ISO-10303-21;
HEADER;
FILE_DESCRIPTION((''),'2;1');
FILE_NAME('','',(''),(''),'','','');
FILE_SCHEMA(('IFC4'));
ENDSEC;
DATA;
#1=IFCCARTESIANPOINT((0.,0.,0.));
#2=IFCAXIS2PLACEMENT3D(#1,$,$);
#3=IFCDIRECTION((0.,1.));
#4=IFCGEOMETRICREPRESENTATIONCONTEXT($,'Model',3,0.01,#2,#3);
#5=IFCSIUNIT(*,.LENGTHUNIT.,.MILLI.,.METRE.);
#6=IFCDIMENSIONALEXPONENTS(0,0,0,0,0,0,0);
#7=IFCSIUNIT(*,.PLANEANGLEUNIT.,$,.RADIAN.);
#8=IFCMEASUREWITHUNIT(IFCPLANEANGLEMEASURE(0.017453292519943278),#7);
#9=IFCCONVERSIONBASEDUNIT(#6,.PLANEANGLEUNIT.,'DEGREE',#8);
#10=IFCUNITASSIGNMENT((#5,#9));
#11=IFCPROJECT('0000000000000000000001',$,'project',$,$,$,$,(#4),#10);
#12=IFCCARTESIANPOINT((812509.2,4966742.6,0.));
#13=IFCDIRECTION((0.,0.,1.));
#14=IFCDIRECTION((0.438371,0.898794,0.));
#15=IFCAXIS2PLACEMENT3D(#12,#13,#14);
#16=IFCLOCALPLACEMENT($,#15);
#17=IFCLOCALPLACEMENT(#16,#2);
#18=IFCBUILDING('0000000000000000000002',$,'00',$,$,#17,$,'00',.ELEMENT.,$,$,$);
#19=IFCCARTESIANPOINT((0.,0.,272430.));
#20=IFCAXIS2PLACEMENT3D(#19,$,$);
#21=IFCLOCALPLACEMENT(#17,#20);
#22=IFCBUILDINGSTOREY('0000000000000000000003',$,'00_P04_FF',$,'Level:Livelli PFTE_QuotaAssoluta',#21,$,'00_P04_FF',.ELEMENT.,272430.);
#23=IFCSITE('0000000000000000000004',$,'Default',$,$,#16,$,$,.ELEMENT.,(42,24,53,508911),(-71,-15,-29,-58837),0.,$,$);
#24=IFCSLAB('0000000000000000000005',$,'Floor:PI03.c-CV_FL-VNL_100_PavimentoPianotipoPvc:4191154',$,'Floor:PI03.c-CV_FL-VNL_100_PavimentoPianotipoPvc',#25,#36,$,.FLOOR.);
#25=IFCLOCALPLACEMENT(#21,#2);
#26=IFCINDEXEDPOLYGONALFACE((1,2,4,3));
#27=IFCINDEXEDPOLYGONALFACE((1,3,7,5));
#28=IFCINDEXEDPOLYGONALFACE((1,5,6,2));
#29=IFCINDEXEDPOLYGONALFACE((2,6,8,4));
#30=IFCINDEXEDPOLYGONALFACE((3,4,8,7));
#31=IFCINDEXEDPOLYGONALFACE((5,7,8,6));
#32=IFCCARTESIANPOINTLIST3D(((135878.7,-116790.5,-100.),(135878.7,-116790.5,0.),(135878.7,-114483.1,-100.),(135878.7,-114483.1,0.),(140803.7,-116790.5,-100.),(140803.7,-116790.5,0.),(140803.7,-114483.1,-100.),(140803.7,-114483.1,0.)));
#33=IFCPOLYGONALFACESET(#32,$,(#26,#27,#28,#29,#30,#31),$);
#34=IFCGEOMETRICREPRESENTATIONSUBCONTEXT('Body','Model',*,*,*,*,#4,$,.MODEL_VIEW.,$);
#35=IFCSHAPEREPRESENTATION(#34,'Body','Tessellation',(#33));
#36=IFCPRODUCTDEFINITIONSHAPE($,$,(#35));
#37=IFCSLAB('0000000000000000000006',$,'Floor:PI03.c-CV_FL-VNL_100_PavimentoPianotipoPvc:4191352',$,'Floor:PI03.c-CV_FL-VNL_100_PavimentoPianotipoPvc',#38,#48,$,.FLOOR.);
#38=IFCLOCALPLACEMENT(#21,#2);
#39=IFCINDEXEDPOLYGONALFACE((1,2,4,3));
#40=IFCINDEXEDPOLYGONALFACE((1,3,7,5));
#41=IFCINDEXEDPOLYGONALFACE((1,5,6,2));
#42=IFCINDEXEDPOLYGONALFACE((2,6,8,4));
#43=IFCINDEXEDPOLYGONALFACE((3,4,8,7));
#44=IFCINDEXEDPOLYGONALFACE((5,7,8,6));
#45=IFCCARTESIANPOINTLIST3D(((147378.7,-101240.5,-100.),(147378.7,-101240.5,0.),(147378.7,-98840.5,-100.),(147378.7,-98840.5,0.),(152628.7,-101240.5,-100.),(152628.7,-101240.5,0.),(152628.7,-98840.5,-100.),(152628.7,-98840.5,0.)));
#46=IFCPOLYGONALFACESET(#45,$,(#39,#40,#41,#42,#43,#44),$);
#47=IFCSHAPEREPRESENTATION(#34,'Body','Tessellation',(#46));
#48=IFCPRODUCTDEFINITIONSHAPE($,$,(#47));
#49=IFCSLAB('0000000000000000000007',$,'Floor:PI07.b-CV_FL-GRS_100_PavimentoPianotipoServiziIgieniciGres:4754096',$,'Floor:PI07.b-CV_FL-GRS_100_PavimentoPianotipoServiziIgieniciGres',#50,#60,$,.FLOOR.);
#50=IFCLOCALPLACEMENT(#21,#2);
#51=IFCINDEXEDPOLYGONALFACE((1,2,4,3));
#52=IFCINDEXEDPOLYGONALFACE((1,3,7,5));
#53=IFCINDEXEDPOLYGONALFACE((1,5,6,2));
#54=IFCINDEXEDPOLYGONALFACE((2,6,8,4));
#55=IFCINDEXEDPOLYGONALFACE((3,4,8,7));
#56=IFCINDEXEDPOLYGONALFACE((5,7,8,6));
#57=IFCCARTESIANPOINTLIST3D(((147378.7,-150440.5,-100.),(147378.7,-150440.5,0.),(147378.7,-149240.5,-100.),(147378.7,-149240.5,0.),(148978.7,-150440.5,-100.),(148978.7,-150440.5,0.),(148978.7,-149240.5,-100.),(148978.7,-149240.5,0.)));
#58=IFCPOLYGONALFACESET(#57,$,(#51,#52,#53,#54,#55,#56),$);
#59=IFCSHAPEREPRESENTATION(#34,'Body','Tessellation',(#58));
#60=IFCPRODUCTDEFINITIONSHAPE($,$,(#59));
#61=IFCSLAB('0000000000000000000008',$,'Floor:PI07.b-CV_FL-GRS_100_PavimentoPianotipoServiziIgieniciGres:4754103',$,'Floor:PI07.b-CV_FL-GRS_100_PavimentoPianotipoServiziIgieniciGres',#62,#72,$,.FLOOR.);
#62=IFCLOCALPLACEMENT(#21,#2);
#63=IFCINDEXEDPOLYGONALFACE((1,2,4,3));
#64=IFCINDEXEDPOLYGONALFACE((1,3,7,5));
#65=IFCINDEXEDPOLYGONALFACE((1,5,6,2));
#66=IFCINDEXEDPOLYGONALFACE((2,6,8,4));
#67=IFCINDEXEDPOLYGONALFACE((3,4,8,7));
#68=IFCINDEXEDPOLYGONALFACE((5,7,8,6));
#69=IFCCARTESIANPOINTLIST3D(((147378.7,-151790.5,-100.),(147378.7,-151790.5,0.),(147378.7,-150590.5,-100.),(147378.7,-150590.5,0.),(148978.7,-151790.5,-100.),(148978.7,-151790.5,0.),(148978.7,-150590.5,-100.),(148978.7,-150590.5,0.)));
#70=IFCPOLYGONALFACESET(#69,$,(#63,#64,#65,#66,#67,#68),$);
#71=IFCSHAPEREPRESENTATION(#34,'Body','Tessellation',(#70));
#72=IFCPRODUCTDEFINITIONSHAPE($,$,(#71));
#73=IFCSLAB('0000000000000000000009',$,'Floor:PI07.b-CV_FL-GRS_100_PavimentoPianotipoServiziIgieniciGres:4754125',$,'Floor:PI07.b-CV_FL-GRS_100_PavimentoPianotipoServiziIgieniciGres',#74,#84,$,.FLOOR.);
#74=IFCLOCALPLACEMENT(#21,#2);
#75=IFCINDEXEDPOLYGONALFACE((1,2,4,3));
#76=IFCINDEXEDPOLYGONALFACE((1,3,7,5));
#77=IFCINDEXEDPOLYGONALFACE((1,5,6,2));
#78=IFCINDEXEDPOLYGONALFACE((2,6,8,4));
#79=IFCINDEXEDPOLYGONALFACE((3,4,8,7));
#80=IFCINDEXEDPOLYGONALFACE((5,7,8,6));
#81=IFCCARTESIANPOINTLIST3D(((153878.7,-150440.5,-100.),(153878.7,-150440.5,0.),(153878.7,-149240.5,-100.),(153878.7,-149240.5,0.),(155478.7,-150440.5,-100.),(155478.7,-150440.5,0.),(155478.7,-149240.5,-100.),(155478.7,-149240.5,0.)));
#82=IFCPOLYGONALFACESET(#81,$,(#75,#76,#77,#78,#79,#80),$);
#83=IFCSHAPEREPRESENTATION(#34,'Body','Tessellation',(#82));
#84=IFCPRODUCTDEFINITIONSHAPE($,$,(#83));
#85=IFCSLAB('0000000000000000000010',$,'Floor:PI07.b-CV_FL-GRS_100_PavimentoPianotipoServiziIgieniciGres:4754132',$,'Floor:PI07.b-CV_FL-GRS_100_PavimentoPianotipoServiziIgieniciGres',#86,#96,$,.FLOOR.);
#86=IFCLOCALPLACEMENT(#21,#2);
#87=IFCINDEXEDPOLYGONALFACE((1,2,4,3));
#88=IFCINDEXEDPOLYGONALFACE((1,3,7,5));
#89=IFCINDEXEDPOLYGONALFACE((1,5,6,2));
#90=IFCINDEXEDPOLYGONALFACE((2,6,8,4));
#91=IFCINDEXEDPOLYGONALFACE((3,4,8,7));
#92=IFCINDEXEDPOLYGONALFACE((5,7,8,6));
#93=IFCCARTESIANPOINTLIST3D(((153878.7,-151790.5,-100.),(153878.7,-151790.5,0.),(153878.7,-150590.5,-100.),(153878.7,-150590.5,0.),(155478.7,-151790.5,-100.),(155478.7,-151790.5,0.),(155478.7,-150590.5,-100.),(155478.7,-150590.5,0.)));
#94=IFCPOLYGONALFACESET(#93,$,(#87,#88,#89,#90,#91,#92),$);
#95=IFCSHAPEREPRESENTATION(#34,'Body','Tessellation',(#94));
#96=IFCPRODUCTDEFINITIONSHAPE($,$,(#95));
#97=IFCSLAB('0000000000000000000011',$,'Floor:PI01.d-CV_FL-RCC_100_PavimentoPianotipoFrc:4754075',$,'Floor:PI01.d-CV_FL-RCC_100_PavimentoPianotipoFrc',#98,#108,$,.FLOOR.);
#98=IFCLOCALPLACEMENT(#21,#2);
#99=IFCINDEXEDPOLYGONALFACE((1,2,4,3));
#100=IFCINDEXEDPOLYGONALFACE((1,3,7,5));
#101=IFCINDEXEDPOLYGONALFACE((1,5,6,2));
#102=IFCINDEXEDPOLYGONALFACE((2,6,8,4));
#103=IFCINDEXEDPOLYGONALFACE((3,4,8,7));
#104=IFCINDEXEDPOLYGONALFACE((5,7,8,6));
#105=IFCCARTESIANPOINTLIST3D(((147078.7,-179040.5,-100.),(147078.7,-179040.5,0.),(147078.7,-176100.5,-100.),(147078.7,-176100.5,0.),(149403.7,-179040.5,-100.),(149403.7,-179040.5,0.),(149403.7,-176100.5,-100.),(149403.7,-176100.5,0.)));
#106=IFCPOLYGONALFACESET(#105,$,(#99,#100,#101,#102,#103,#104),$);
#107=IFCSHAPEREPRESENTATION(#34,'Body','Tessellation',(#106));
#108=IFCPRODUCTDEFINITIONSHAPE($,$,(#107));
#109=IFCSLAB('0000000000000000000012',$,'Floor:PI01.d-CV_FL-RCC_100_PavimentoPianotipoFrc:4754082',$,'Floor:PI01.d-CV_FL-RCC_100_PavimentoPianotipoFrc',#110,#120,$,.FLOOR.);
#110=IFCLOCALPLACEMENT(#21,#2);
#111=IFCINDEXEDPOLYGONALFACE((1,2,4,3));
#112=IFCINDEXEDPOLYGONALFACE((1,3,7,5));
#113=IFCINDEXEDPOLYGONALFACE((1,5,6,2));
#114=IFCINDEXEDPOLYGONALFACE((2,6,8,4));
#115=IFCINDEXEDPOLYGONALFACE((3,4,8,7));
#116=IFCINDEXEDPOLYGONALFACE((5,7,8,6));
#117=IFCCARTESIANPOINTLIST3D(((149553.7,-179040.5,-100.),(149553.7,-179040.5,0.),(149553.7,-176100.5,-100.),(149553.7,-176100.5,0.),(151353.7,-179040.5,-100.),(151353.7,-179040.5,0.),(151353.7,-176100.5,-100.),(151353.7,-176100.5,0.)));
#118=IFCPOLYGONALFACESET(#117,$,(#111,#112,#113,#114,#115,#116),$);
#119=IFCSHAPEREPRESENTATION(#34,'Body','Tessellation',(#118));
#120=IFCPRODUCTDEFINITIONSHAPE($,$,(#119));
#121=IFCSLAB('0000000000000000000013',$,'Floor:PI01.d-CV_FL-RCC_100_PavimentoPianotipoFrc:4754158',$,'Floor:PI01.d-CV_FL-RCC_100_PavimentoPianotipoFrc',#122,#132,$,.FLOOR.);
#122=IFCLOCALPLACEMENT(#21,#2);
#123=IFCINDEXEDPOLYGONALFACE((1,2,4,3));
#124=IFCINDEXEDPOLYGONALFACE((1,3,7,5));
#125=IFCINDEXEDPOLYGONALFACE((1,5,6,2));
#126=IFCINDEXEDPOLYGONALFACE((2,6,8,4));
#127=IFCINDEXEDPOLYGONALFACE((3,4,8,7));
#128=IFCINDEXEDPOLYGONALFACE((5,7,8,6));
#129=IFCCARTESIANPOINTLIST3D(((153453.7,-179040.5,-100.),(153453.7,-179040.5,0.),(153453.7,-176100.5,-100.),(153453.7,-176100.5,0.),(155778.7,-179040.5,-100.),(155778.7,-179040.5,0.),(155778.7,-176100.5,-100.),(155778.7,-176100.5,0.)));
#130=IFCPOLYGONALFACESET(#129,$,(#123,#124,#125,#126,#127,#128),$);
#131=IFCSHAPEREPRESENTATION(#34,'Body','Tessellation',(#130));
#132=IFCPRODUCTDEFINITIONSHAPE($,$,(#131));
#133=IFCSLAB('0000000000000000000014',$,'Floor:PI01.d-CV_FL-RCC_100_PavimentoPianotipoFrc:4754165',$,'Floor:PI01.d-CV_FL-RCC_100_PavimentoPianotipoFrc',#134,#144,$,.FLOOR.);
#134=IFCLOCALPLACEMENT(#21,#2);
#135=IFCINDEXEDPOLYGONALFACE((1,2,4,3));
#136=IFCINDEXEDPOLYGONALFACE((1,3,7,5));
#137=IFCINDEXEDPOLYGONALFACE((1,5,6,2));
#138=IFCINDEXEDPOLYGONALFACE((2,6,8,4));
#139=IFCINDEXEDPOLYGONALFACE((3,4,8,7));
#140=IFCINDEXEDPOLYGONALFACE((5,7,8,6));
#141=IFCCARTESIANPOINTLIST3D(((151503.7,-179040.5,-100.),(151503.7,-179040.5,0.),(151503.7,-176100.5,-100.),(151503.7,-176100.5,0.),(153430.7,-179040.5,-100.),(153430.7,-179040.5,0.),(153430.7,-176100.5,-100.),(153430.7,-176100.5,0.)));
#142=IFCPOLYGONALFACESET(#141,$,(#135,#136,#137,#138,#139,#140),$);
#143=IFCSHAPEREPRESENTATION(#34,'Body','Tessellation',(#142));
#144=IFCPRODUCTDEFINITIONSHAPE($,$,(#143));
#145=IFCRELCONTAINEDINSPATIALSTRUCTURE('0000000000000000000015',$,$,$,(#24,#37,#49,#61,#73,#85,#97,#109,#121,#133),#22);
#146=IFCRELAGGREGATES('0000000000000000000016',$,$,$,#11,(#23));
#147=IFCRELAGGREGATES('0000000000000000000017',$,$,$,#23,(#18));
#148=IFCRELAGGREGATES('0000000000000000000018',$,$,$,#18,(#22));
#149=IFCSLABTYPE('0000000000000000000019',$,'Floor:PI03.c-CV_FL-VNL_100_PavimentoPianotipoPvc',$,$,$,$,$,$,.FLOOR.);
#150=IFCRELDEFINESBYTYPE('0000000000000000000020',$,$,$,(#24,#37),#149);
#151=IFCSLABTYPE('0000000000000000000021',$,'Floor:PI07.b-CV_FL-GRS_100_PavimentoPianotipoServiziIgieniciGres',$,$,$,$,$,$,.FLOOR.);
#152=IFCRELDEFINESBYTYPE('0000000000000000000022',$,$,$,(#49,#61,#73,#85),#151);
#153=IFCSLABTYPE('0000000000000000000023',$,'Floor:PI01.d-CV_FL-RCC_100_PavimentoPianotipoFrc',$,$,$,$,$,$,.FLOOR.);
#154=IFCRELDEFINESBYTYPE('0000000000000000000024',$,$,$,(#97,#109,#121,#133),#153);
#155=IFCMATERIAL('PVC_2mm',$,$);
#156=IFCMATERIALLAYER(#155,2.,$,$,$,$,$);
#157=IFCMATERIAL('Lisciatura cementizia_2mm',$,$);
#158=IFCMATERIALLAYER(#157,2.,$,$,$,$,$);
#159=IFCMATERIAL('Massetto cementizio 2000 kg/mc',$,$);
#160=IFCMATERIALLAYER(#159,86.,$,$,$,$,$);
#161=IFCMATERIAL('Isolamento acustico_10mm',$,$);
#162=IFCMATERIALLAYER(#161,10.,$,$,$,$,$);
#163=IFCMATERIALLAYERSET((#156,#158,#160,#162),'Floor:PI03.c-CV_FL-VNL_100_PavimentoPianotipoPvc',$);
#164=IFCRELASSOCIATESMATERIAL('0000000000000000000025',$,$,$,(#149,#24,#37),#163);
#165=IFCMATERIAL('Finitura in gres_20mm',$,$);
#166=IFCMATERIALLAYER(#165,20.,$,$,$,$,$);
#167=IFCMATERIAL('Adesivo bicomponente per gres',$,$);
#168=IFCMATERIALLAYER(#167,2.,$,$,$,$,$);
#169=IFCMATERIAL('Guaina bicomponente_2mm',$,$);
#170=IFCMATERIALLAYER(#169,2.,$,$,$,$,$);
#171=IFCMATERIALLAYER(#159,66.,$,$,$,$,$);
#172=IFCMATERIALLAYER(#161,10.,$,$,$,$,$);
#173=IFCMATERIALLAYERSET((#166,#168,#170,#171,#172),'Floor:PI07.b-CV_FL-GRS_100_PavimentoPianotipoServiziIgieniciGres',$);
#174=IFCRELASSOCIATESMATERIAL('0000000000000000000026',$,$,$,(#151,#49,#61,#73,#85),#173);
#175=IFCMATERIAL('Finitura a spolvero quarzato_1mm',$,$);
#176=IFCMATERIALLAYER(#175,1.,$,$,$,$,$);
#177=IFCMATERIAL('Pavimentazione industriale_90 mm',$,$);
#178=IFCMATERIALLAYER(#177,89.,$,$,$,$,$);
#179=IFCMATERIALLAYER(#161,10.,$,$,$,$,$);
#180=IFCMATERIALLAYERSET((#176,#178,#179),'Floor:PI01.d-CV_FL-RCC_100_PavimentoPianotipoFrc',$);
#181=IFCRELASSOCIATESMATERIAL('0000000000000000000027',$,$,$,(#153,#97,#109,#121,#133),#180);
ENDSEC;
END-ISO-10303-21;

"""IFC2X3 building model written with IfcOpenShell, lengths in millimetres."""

from ifc_helpers import new_model, entity, si_unit, converted_unit, direction, frame, frame_2d, origin, place, context, subcontext, project, spatial, rectangle, extrude, material, layer, layer_set, layer_usage, type_object, element, save


model = new_model("IFC2X3")

# Units and contexts
model_context = context("Model", 3, precision=0.01, world=origin(), true_north=direction((0.0, 1.0)))
body_context = subcontext(model_context, "Body", "Model", "MODEL_VIEW")
ifc_project = project(units=[si_unit("LENGTHUNIT", "METRE", prefix="MILLI"), converted_unit("PLANEANGLEUNIT", "DEGREE", entity("IfcPlaneAngleMeasure", 0.017453292519943278), si_unit("PLANEANGLEUNIT", "RADIAN"), dimensions=[0, 0, 0, 0, 0, 0, 0])], contexts=[model_context])

# Site, building, storey
site_placement = place(None, frame((812509.2, 4966742.6, 0.0), z_axis=(0.0, 0.0, 1.0), x_axis=(0.438371, 0.898794, 0.0)))
site = spatial("IfcSite", under=ifc_project, at=site_placement, Name="Default", CompositionType="ELEMENT", RefLatitude=(42, 24, 53, 508911), RefLongitude=(-71, -15, -29, -58837), RefElevation=0.0)
building_placement = place(site_placement, origin())
building = spatial("IfcBuilding", under=site, at=building_placement, Name="00", LongName="00", CompositionType="ELEMENT")
storey_placement = place(building_placement, frame((0.0, 0.0, 272430.0)))
storey = spatial("IfcBuildingStorey", under=building, at=storey_placement, Name="00_P04_FF", ObjectType="Level:Livelli PFTE_QuotaAssoluta", LongName="00_P04_FF", CompositionType="ELEMENT", Elevation=272430.0)

# Slabs
ifc_material_1 = material(Name="PVC_2mm")
ifc_layer_1 = layer(ifc_material_1, 2.0)
ifc_material_2 = material(Name="Lisciatura cementizia_2mm")
ifc_layer_2 = layer(ifc_material_2, 2.0)
ifc_material_3 = material(Name="Massetto cementizio 2000 kg/mc")
ifc_layer_3 = layer(ifc_material_3, 86.0)
ifc_material_4 = material(Name="Isolamento acustico_10mm")
ifc_layer_4 = layer(ifc_material_4, 10.0)
ifc_layer_set_1 = layer_set([ifc_layer_1, ifc_layer_2, ifc_layer_3, ifc_layer_4], Name="Floor:PI03.c-CV_FL-VNL_100_PavimentoPianotipoPvc")
ifc_layer_usage_1 = layer_usage(ifc_layer_set_1, "AXIS3", "POSITIVE", 0.0)
slab_type_1 = type_object("IfcSlabType", Name="Floor:PI03.c-CV_FL-VNL_100_PavimentoPianotipoPvc", PredefinedType="FLOOR", material=ifc_layer_set_1)
slab_1_placement = place(storey_placement, origin())
element("IfcSlab", 1, at=slab_1_placement, inside=storey, type_object=slab_type_1, material=ifc_layer_usage_1, Name="Floor:PI03.c-CV_FL-VNL_100_PavimentoPianotipoPvc:4191154", ObjectType="Floor:PI03.c-CV_FL-VNL_100_PavimentoPianotipoPvc", PredefinedType="FLOOR", context=body_context, shape_type="SweptSolid", body=[
    extrude(rectangle(XDim=2307.4, YDim=4925.0, at=frame_2d((0.0, 0.0), x_axis=(1.0, 0.0))), frame((138341.2, -115636.8, 0.0), z_axis=(0.0, 0.0, -1.0), x_axis=(0.0, 1.0, 0.0)), (0.0, 0.0, 1.0), 100.0),
])
ifc_layer_usage_2 = layer_usage(ifc_layer_set_1, "AXIS3", "POSITIVE", 0.0)
slab_2_placement = place(storey_placement, origin())
element("IfcSlab", 2, at=slab_2_placement, inside=storey, type_object=slab_type_1, material=ifc_layer_usage_2, Name="Floor:PI03.c-CV_FL-VNL_100_PavimentoPianotipoPvc:4191352", ObjectType="Floor:PI03.c-CV_FL-VNL_100_PavimentoPianotipoPvc", PredefinedType="FLOOR", context=body_context, shape_type="SweptSolid", body=[
    extrude(rectangle(XDim=2400.0, YDim=5250.0, at=frame_2d((0.0, 0.0), x_axis=(1.0, 0.0))), frame((150003.7, -100040.5, 0.0), z_axis=(0.0, 0.0, -1.0), x_axis=(0.0, 1.0, 0.0)), (0.0, 0.0, 1.0), 100.0),
])

# Slabs
ifc_material_5 = material(Name="Finitura in gres_20mm")
ifc_layer_5 = layer(ifc_material_5, 20.0)
ifc_material_6 = material(Name="Adesivo bicomponente per gres")
ifc_layer_6 = layer(ifc_material_6, 2.0)
ifc_material_7 = material(Name="Guaina bicomponente_2mm")
ifc_layer_7 = layer(ifc_material_7, 2.0)
ifc_layer_8 = layer(ifc_material_3, 66.0)
ifc_layer_9 = layer(ifc_material_4, 10.0)
ifc_layer_set_2 = layer_set([ifc_layer_5, ifc_layer_6, ifc_layer_7, ifc_layer_8, ifc_layer_9], Name="Floor:PI07.b-CV_FL-GRS_100_PavimentoPianotipoServiziIgieniciGres")
ifc_layer_usage_3 = layer_usage(ifc_layer_set_2, "AXIS3", "POSITIVE", 0.0)
slab_type_2 = type_object("IfcSlabType", Name="Floor:PI07.b-CV_FL-GRS_100_PavimentoPianotipoServiziIgieniciGres", PredefinedType="FLOOR", material=ifc_layer_set_2)
slab_3_placement = place(storey_placement, origin())
element("IfcSlab", 3, at=slab_3_placement, inside=storey, type_object=slab_type_2, material=ifc_layer_usage_3, Name="Floor:PI07.b-CV_FL-GRS_100_PavimentoPianotipoServiziIgieniciGres:4754096", ObjectType="Floor:PI07.b-CV_FL-GRS_100_PavimentoPianotipoServiziIgieniciGres", PredefinedType="FLOOR", context=body_context, shape_type="SweptSolid", body=[
    extrude(rectangle(XDim=1200.0, YDim=1600.0, at=frame_2d((0.0, 0.0), x_axis=(1.0, 0.0))), frame((148178.7, -149840.5, 0.0), z_axis=(0.0, 0.0, -1.0), x_axis=(0.0, 1.0, 0.0)), (0.0, 0.0, 1.0), 100.0),
])
ifc_layer_usage_4 = layer_usage(ifc_layer_set_2, "AXIS3", "POSITIVE", 0.0)
slab_4_placement = place(storey_placement, origin())
element("IfcSlab", 4, at=slab_4_placement, inside=storey, type_object=slab_type_2, material=ifc_layer_usage_4, Name="Floor:PI07.b-CV_FL-GRS_100_PavimentoPianotipoServiziIgieniciGres:4754103", ObjectType="Floor:PI07.b-CV_FL-GRS_100_PavimentoPianotipoServiziIgieniciGres", PredefinedType="FLOOR", context=body_context, shape_type="SweptSolid", body=[
    extrude(rectangle(XDim=1200.0, YDim=1600.0, at=frame_2d((0.0, 0.0), x_axis=(1.0, 0.0))), frame((148178.7, -151190.5, 0.0), z_axis=(0.0, 0.0, -1.0), x_axis=(0.0, 1.0, 0.0)), (0.0, 0.0, 1.0), 100.0),
])
ifc_layer_usage_5 = layer_usage(ifc_layer_set_2, "AXIS3", "POSITIVE", 0.0)
slab_5_placement = place(storey_placement, origin())
element("IfcSlab", 5, at=slab_5_placement, inside=storey, type_object=slab_type_2, material=ifc_layer_usage_5, Name="Floor:PI07.b-CV_FL-GRS_100_PavimentoPianotipoServiziIgieniciGres:4754125", ObjectType="Floor:PI07.b-CV_FL-GRS_100_PavimentoPianotipoServiziIgieniciGres", PredefinedType="FLOOR", context=body_context, shape_type="SweptSolid", body=[
    extrude(rectangle(XDim=1200.0, YDim=1600.0, at=frame_2d((0.0, 0.0), x_axis=(1.0, 0.0))), frame((154678.7, -149840.5, 0.0), z_axis=(0.0, 0.0, -1.0), x_axis=(0.0, 1.0, 0.0)), (0.0, 0.0, 1.0), 100.0),
])
ifc_layer_usage_6 = layer_usage(ifc_layer_set_2, "AXIS3", "POSITIVE", 0.0)
slab_6_placement = place(storey_placement, origin())
element("IfcSlab", 6, at=slab_6_placement, inside=storey, type_object=slab_type_2, material=ifc_layer_usage_6, Name="Floor:PI07.b-CV_FL-GRS_100_PavimentoPianotipoServiziIgieniciGres:4754132", ObjectType="Floor:PI07.b-CV_FL-GRS_100_PavimentoPianotipoServiziIgieniciGres", PredefinedType="FLOOR", context=body_context, shape_type="SweptSolid", body=[
    extrude(rectangle(XDim=1200.0, YDim=1600.0, at=frame_2d((0.0, 0.0), x_axis=(1.0, 0.0))), frame((154678.7, -151190.5, 0.0), z_axis=(0.0, 0.0, -1.0), x_axis=(0.0, 1.0, 0.0)), (0.0, 0.0, 1.0), 100.0),
])
ifc_material_8 = material(Name="Finitura a spolvero quarzato_1mm")
ifc_layer_10 = layer(ifc_material_8, 1.0)
ifc_material_9 = material(Name="Pavimentazione industriale_90 mm")
ifc_layer_11 = layer(ifc_material_9, 89.0)
ifc_layer_12 = layer(ifc_material_4, 10.0)
ifc_layer_set_3 = layer_set([ifc_layer_10, ifc_layer_11, ifc_layer_12], Name="Floor:PI01.d-CV_FL-RCC_100_PavimentoPianotipoFrc")
slab_type_3 = type_object("IfcSlabType", Name="Floor:PI01.d-CV_FL-RCC_100_PavimentoPianotipoFrc", PredefinedType="FLOOR", material=ifc_layer_set_3)
ifc_layer_usage_7 = layer_usage(ifc_layer_set_3, "AXIS3", "POSITIVE", 0.0)
slab_7_placement = place(storey_placement, origin())
element("IfcSlab", 7, at=slab_7_placement, inside=storey, type_object=slab_type_3, material=ifc_layer_usage_7, Name="Floor:PI01.d-CV_FL-RCC_100_PavimentoPianotipoFrc:4754075", ObjectType="Floor:PI01.d-CV_FL-RCC_100_PavimentoPianotipoFrc", PredefinedType="FLOOR", context=body_context, shape_type="SweptSolid", body=[
    extrude(rectangle(XDim=2940.0, YDim=2325.0, at=frame_2d((0.0, 0.0), x_axis=(1.0, 0.0))), frame((148241.2, -177570.5, 0.0), z_axis=(0.0, 0.0, -1.0), x_axis=(0.0, 1.0, 0.0)), (0.0, 0.0, 1.0), 100.0),
])
ifc_layer_usage_8 = layer_usage(ifc_layer_set_3, "AXIS3", "POSITIVE", 0.0)
slab_8_placement = place(storey_placement, origin())
element("IfcSlab", 8, at=slab_8_placement, inside=storey, type_object=slab_type_3, material=ifc_layer_usage_8, Name="Floor:PI01.d-CV_FL-RCC_100_PavimentoPianotipoFrc:4754082", ObjectType="Floor:PI01.d-CV_FL-RCC_100_PavimentoPianotipoFrc", PredefinedType="FLOOR", context=body_context, shape_type="SweptSolid", body=[
    extrude(rectangle(XDim=2940.0, YDim=1800.0, at=frame_2d((0.0, 0.0), x_axis=(1.0, 0.0))), frame((150453.7, -177570.5, 0.0), z_axis=(0.0, 0.0, -1.0), x_axis=(0.0, 1.0, 0.0)), (0.0, 0.0, 1.0), 100.0),
])
ifc_layer_usage_9 = layer_usage(ifc_layer_set_3, "AXIS3", "POSITIVE", 0.0)
slab_9_placement = place(storey_placement, origin())
element("IfcSlab", 9, at=slab_9_placement, inside=storey, type_object=slab_type_3, material=ifc_layer_usage_9, Name="Floor:PI01.d-CV_FL-RCC_100_PavimentoPianotipoFrc:4754158", ObjectType="Floor:PI01.d-CV_FL-RCC_100_PavimentoPianotipoFrc", PredefinedType="FLOOR", context=body_context, shape_type="SweptSolid", body=[
    extrude(rectangle(XDim=2940.0, YDim=2325.0, at=frame_2d((0.0, 0.0), x_axis=(1.0, 0.0))), frame((154616.2, -177570.5, 0.0), z_axis=(0.0, 0.0, -1.0), x_axis=(0.0, 1.0, 0.0)), (0.0, 0.0, 1.0), 100.0),
])
ifc_layer_usage_10 = layer_usage(ifc_layer_set_3, "AXIS3", "POSITIVE", 0.0)
slab_10_placement = place(storey_placement, origin())
element("IfcSlab", 10, at=slab_10_placement, inside=storey, type_object=slab_type_3, material=ifc_layer_usage_10, Name="Floor:PI01.d-CV_FL-RCC_100_PavimentoPianotipoFrc:4754165", ObjectType="Floor:PI01.d-CV_FL-RCC_100_PavimentoPianotipoFrc", PredefinedType="FLOOR", context=body_context, shape_type="SweptSolid", body=[
    extrude(rectangle(XDim=2940.0, YDim=1927.0, at=frame_2d((0.0, 0.0), x_axis=(1.0, 0.0))), frame((152467.2, -177570.5, 0.0), z_axis=(0.0, 0.0, -1.0), x_axis=(0.0, 1.0, 0.0)), (0.0, 0.0, 1.0), 100.0),
])

save(model, "model.ifc")
